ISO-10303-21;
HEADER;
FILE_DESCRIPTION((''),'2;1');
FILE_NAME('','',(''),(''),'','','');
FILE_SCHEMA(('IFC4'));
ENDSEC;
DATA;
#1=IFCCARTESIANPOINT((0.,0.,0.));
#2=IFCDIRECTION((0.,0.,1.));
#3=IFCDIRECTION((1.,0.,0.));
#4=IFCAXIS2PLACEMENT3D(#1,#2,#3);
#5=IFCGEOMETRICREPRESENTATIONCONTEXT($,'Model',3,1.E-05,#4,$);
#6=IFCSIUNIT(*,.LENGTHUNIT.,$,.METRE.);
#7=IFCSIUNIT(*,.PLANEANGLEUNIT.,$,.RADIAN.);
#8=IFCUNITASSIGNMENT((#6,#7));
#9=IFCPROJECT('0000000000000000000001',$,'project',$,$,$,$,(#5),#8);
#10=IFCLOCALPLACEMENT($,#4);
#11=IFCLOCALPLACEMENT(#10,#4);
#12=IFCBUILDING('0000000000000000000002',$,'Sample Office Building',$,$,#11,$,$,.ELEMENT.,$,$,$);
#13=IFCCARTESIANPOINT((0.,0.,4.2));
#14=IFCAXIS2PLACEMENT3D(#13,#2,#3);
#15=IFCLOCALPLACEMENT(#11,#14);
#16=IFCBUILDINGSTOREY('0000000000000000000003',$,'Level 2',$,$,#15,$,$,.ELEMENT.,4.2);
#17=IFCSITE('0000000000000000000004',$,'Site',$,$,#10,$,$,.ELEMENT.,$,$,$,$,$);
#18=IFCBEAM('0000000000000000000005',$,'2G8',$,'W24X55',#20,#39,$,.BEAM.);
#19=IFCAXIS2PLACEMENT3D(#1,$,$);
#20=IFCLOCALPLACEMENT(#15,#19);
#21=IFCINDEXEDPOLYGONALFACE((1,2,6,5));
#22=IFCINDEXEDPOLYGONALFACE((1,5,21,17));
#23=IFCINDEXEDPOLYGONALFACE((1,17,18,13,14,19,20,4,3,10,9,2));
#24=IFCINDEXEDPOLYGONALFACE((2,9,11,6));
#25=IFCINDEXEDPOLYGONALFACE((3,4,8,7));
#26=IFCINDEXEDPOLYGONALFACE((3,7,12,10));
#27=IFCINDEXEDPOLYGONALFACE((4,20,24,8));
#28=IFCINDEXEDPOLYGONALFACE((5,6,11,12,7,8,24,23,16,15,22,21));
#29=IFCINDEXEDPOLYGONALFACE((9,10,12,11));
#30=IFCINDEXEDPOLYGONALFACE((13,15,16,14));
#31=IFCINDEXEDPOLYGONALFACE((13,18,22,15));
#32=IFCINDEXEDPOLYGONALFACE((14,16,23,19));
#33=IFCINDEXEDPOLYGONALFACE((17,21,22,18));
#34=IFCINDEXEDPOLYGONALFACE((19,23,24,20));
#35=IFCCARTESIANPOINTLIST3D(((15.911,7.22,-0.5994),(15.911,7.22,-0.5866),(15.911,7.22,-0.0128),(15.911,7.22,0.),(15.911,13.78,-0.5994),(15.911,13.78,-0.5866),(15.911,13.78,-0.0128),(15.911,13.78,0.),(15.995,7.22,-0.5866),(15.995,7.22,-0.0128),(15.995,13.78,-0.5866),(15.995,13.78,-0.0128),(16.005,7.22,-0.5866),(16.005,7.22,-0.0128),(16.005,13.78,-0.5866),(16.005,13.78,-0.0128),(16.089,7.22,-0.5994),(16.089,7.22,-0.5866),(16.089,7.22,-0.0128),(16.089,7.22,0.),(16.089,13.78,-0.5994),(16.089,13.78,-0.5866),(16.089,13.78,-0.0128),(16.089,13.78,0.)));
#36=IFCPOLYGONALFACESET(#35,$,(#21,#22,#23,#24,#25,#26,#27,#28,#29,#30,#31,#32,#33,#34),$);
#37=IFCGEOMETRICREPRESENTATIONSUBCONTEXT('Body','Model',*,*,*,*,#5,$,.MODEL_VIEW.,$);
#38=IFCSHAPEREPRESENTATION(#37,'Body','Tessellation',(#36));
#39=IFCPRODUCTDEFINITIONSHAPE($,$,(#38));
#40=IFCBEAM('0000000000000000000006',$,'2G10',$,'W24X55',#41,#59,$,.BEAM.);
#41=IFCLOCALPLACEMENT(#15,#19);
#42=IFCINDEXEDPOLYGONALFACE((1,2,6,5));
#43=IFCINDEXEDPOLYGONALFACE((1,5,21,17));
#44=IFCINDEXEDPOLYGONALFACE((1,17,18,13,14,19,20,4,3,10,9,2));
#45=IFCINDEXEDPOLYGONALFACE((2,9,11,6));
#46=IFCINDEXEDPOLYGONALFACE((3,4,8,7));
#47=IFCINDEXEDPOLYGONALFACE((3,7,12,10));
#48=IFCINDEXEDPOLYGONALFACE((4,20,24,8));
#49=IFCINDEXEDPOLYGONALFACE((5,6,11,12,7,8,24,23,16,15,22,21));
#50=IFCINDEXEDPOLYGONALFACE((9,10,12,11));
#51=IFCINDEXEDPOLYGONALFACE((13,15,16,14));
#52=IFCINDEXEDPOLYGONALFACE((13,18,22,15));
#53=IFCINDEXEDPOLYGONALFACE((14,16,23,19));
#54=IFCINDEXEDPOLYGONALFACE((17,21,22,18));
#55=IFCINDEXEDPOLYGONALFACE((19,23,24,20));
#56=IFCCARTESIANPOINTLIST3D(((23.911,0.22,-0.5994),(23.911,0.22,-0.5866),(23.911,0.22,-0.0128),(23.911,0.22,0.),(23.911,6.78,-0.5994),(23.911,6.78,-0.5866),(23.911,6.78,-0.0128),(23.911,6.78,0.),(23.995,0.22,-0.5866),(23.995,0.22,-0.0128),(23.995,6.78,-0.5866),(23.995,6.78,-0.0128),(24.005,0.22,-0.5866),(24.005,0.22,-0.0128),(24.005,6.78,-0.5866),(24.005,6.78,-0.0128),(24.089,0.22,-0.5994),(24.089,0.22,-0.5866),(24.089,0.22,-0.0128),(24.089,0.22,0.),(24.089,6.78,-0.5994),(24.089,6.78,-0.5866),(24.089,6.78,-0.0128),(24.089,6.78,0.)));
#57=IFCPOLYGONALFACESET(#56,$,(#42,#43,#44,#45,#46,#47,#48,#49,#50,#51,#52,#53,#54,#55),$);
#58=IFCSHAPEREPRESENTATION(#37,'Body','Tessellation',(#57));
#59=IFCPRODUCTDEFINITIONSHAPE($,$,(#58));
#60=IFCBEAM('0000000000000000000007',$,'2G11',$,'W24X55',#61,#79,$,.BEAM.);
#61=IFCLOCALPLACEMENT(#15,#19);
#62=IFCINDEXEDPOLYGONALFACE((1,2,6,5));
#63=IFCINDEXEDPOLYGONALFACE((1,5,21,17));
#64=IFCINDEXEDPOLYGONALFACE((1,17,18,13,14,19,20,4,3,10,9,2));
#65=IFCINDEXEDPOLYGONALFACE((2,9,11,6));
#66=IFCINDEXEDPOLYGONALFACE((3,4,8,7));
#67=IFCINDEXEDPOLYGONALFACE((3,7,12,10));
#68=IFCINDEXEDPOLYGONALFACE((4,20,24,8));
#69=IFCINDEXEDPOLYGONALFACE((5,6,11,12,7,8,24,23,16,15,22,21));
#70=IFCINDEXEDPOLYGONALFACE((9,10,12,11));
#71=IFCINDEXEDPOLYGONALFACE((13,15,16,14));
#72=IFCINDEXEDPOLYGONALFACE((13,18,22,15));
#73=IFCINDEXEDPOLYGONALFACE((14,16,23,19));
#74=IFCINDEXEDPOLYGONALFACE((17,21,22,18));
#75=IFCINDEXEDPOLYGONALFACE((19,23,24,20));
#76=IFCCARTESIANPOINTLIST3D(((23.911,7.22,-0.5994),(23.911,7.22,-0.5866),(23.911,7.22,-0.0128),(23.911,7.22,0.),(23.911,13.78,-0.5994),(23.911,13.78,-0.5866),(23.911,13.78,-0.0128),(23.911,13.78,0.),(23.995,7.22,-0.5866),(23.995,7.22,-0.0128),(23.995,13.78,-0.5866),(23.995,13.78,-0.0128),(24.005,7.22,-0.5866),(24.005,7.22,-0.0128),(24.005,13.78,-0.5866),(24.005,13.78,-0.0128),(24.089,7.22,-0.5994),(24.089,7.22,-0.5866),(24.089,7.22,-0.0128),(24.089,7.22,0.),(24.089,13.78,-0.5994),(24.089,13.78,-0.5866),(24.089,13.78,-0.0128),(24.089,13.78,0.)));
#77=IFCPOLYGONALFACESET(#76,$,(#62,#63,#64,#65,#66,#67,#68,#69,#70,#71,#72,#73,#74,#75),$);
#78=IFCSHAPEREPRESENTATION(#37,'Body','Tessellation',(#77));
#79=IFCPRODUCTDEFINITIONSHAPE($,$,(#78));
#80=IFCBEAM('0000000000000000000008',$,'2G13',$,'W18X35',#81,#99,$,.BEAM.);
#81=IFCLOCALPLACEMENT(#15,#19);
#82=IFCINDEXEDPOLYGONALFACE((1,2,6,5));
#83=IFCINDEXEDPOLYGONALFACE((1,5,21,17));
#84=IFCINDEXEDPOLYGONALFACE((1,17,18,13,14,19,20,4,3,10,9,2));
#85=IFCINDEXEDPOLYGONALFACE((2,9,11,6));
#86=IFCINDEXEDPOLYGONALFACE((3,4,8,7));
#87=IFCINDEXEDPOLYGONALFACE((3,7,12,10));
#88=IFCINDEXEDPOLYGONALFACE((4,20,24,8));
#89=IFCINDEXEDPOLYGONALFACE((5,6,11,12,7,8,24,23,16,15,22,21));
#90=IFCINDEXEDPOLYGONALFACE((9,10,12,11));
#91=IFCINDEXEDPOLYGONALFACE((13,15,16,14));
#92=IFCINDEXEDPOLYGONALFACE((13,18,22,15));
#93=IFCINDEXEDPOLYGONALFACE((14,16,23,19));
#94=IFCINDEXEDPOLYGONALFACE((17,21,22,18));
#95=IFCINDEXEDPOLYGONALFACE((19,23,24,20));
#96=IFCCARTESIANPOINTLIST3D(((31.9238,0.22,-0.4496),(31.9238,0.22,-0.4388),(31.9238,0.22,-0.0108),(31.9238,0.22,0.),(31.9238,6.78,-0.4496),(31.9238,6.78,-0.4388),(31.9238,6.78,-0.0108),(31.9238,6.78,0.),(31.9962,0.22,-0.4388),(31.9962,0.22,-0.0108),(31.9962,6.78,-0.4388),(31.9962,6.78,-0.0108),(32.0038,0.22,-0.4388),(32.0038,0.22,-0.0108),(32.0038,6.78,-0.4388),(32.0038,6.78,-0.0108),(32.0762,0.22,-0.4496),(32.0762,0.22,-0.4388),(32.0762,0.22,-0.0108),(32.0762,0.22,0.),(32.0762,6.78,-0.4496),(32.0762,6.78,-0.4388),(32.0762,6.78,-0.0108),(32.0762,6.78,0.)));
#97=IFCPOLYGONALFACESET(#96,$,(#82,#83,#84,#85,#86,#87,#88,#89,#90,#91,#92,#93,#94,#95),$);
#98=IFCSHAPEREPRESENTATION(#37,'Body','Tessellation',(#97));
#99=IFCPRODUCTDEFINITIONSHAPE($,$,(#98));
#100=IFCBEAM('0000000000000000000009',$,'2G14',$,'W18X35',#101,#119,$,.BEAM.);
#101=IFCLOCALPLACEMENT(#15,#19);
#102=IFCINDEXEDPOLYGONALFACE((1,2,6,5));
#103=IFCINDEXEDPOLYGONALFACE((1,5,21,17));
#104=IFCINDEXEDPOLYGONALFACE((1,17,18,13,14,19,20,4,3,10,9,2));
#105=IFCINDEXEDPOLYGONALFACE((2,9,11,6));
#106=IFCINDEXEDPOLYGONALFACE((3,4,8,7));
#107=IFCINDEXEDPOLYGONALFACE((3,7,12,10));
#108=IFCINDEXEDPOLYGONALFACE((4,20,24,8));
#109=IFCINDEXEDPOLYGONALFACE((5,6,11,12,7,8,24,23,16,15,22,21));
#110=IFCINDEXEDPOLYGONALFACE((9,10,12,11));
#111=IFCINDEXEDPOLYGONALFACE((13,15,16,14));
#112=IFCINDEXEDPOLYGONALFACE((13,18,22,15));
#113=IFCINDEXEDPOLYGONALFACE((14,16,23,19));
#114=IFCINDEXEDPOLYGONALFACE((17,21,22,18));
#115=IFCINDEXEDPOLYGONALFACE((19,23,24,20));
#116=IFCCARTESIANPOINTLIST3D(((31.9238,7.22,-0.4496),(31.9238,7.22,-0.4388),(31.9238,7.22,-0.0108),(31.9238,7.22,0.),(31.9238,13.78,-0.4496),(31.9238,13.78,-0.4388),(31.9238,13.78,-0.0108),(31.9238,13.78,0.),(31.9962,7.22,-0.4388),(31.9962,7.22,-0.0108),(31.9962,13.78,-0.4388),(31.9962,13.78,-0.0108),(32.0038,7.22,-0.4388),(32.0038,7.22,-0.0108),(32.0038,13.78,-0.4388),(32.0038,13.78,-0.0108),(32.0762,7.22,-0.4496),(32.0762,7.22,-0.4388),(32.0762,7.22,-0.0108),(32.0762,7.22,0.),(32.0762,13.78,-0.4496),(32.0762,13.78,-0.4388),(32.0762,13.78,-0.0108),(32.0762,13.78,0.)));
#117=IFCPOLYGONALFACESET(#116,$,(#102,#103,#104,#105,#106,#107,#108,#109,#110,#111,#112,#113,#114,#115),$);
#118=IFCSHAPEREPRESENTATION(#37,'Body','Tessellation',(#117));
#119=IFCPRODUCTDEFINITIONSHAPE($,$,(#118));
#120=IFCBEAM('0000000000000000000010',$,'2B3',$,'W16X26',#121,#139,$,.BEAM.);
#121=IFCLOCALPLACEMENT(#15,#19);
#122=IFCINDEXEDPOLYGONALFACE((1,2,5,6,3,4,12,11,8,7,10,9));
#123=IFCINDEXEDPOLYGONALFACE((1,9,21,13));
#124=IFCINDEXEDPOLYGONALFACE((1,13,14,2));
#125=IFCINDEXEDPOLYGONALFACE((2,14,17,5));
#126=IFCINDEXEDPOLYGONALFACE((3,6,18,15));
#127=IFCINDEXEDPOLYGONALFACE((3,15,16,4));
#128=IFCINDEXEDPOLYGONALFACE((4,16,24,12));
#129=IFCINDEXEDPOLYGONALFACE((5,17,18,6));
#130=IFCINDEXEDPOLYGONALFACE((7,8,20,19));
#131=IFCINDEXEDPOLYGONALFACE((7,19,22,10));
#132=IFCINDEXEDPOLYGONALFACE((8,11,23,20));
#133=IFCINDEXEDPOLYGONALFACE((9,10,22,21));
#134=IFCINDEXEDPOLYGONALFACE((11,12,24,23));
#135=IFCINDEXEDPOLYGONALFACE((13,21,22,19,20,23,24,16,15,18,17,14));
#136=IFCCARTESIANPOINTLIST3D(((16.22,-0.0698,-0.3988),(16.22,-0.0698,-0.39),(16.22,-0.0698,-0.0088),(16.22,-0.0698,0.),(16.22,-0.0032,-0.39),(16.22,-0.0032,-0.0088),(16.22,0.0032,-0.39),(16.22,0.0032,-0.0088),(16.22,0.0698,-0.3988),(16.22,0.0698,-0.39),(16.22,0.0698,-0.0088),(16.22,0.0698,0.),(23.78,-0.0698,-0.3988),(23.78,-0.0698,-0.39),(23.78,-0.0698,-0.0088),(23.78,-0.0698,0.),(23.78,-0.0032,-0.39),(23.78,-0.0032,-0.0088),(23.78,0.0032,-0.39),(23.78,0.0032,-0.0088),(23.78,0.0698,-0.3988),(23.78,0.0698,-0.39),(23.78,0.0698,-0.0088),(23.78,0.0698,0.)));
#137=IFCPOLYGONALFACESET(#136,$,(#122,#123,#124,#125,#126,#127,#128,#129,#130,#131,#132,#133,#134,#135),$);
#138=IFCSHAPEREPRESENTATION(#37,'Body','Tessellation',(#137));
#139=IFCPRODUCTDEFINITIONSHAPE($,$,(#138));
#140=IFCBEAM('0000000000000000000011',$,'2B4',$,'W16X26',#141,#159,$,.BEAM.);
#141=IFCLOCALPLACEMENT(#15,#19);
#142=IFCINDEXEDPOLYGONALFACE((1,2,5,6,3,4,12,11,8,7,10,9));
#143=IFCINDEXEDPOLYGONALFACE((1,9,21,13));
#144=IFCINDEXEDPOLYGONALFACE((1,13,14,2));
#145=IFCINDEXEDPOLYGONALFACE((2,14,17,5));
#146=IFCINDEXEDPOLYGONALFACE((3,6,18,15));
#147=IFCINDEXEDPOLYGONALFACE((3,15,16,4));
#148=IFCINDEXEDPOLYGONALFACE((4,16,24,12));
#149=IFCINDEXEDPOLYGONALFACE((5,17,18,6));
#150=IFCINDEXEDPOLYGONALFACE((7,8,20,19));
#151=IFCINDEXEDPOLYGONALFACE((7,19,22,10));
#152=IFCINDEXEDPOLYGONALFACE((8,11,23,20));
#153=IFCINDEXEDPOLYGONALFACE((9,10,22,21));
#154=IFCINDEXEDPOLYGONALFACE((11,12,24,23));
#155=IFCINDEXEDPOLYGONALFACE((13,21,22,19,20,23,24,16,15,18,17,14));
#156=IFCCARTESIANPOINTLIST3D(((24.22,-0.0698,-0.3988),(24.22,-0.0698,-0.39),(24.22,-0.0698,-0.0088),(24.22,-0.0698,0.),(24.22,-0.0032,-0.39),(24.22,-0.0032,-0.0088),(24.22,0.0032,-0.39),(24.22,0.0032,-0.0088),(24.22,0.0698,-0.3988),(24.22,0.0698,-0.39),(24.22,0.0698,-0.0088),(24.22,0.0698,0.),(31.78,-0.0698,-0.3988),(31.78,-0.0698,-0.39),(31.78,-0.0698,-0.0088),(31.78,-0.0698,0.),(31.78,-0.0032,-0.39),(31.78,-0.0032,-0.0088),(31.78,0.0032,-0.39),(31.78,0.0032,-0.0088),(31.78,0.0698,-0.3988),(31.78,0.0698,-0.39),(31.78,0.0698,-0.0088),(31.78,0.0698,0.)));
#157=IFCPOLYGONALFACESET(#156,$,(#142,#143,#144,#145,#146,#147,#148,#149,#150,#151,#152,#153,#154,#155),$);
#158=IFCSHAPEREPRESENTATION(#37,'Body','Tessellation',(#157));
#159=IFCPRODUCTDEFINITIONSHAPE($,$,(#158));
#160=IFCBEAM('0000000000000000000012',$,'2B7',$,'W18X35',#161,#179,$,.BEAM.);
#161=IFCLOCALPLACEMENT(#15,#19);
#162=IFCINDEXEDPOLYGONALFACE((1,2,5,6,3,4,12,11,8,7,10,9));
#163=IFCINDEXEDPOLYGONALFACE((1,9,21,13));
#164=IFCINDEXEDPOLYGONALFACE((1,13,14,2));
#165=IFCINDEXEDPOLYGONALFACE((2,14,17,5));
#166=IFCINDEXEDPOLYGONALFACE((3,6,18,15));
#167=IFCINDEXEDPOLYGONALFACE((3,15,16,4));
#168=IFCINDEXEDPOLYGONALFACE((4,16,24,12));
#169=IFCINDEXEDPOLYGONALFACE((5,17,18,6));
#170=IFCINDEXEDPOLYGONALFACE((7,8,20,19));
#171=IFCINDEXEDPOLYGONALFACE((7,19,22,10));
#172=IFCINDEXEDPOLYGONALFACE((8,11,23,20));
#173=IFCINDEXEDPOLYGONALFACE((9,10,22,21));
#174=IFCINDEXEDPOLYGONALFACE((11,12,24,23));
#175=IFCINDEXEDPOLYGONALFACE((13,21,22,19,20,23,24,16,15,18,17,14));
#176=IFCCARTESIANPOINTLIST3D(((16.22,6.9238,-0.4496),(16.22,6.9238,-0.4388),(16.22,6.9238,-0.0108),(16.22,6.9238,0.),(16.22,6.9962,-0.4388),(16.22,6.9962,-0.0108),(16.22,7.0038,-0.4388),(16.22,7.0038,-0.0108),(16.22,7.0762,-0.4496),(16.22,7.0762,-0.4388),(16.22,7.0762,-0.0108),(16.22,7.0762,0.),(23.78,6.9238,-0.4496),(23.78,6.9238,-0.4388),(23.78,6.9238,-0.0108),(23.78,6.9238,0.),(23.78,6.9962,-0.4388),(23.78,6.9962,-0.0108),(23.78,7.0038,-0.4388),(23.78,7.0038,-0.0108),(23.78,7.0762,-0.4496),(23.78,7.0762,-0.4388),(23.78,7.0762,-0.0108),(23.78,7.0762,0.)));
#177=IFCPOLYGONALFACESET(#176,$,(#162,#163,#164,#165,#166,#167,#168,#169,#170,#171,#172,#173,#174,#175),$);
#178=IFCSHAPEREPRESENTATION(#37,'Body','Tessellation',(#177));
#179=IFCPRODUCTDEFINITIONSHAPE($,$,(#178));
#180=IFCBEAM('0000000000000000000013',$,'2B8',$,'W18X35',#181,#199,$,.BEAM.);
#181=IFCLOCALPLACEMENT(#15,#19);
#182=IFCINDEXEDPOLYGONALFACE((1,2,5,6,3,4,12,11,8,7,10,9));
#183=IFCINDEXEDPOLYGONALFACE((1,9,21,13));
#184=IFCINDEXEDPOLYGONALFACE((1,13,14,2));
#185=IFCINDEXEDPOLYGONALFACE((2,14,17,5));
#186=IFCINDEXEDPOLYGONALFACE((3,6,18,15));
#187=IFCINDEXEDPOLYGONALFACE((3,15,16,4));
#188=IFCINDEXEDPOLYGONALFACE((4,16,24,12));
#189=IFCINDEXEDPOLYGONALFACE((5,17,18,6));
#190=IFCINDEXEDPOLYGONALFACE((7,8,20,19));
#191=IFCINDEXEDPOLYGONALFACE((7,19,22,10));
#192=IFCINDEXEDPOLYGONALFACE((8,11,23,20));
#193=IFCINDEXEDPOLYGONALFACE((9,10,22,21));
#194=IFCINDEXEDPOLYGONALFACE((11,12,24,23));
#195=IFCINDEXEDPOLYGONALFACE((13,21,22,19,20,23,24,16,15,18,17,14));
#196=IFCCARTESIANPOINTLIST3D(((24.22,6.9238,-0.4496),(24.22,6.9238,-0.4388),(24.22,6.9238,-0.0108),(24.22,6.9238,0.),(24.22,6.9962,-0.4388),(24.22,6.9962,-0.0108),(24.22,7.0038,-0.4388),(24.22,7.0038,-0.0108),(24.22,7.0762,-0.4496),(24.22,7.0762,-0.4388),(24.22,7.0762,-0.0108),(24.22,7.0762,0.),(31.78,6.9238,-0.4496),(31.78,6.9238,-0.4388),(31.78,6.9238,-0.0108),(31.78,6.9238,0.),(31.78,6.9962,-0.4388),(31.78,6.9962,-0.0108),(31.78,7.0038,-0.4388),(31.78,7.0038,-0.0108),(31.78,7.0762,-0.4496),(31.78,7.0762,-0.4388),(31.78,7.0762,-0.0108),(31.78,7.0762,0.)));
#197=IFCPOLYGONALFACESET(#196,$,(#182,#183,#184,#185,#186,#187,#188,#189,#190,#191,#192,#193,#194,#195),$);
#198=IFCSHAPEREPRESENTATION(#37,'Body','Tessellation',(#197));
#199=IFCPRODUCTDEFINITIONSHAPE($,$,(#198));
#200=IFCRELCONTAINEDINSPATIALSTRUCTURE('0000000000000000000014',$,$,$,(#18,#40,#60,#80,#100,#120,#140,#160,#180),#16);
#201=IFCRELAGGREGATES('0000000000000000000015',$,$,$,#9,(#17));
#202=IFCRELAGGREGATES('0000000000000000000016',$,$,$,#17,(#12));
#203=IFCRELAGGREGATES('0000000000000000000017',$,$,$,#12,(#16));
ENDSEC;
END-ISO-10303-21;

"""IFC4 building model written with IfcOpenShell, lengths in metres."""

from ifc_helpers import new_model, si_unit, frame, origin_with_axes, place, context, subcontext, project, spatial, i_section, extrude, element, save


model = new_model("IFC4")

# Units and contexts
model_context = context("Model", 3, precision=1e-05, world=origin_with_axes())
body_context = subcontext(model_context, "Body", "Model", "MODEL_VIEW")
ifc_project = project(units=[si_unit("LENGTHUNIT", "METRE"), si_unit("PLANEANGLEUNIT", "RADIAN")], contexts=[model_context])

# Site, building, storey
site_placement = place(None, origin_with_axes())
site = spatial("IfcSite", under=ifc_project, at=site_placement, Name="Site", CompositionType="ELEMENT")
building_placement = place(site_placement, origin_with_axes())
building = spatial("IfcBuilding", under=site, at=building_placement, Name="Sample Office Building", CompositionType="ELEMENT")
storey_placement = place(building_placement, frame((0.0, 0.0, 4.2), z_axis=(0.0, 0.0, 1.0), x_axis=(1.0, 0.0, 0.0)))
storey = spatial("IfcBuildingStorey", under=building, at=storey_placement, Name="Level 2", CompositionType="ELEMENT", Elevation=4.2)

# Beams
beam_1_placement = place(None, frame((16.0, 7.22, 3.9003), z_axis=(0.0, 1.0, 0.0), x_axis=(-1.0, 0.0, 0.0)))
element("IfcBeam", 1, at=beam_1_placement, inside=storey, Name="2G8", ObjectType="W24X55", PredefinedType="BEAM", context=body_context, shape_type="SweptSolid", body=[
    extrude(i_section(OverallWidth=0.1781, OverallDepth=0.5994, WebThickness=0.01, FlangeThickness=0.0128), None, (0.0, 0.0, 1.0), 6.56),
])
beam_2_placement = place(None, frame((24.0, 0.22, 3.9003), z_axis=(0.0, 1.0, 0.0), x_axis=(-1.0, 0.0, 0.0)))
element("IfcBeam", 2, at=beam_2_placement, inside=storey, Name="2G10", ObjectType="W24X55", PredefinedType="BEAM", context=body_context, shape_type="SweptSolid", body=[
    extrude(i_section(OverallWidth=0.1781, OverallDepth=0.5994, WebThickness=0.01, FlangeThickness=0.0128), None, (0.0, 0.0, 1.0), 6.56),
])
beam_3_placement = place(None, frame((24.0, 7.22, 3.9003), z_axis=(0.0, 1.0, 0.0), x_axis=(-1.0, 0.0, 0.0)))
element("IfcBeam", 3, at=beam_3_placement, inside=storey, Name="2G11", ObjectType="W24X55", PredefinedType="BEAM", context=body_context, shape_type="SweptSolid", body=[
    extrude(i_section(OverallWidth=0.1781, OverallDepth=0.5994, WebThickness=0.01, FlangeThickness=0.0128), None, (0.0, 0.0, 1.0), 6.56),
])
beam_4_placement = place(None, frame((32.0, 0.22, 3.9752), z_axis=(0.0, 1.0, 0.0), x_axis=(-1.0, 0.0, 0.0)))
element("IfcBeam", 4, at=beam_4_placement, inside=storey, Name="2G13", ObjectType="W18X35", PredefinedType="BEAM", context=body_context, shape_type="SweptSolid", body=[
    extrude(i_section(OverallWidth=0.1524, OverallDepth=0.4496, WebThickness=0.0076, FlangeThickness=0.0108), None, (0.0, 0.0, 1.0), 6.56),
])
beam_5_placement = place(None, frame((32.0, 7.22, 3.9752), z_axis=(0.0, 1.0, 0.0), x_axis=(-1.0, 0.0, 0.0)))
element("IfcBeam", 5, at=beam_5_placement, inside=storey, Name="2G14", ObjectType="W18X35", PredefinedType="BEAM", context=body_context, shape_type="SweptSolid", body=[
    extrude(i_section(OverallWidth=0.1524, OverallDepth=0.4496, WebThickness=0.0076, FlangeThickness=0.0108), None, (0.0, 0.0, 1.0), 6.56),
])
for number, where, z_axis, x_axis, name in (
    (6, (16.22, 0.0, 4.0006), (1.0, 0.0, 0.0), (0.0, 1.0, 0.0), "2B3"),
    (7, (24.22, 0.0, 4.0006), (1.0, 0.0, 0.0), (0.0, 1.0, 0.0), "2B4"),
):
    element("IfcBeam", number, at=place(None, frame(where, z_axis=z_axis, x_axis=x_axis)), inside=storey, Name=name, ObjectType="W16X26", PredefinedType="BEAM", context=body_context, shape_type="SweptSolid", body=[
        extrude(i_section(OverallWidth=0.1397, OverallDepth=0.3988, WebThickness=0.0063, FlangeThickness=0.0088), None, (0.0, 0.0, 1.0), 7.56),
    ])
for number, where, z_axis, x_axis, name in (
    (8, (16.22, 7.0, 3.9752), (1.0, 0.0, 0.0), (0.0, 1.0, 0.0), "2B7"),
    (9, (24.22, 7.0, 3.9752), (1.0, 0.0, 0.0), (0.0, 1.0, 0.0), "2B8"),
):
    element("IfcBeam", number, at=place(None, frame(where, z_axis=z_axis, x_axis=x_axis)), inside=storey, Name=name, ObjectType="W18X35", PredefinedType="BEAM", context=body_context, shape_type="SweptSolid", body=[
        extrude(i_section(OverallWidth=0.1524, OverallDepth=0.4496, WebThickness=0.0076, FlangeThickness=0.0108), None, (0.0, 0.0, 1.0), 7.56),
    ])

save(model, "model.ifc")
